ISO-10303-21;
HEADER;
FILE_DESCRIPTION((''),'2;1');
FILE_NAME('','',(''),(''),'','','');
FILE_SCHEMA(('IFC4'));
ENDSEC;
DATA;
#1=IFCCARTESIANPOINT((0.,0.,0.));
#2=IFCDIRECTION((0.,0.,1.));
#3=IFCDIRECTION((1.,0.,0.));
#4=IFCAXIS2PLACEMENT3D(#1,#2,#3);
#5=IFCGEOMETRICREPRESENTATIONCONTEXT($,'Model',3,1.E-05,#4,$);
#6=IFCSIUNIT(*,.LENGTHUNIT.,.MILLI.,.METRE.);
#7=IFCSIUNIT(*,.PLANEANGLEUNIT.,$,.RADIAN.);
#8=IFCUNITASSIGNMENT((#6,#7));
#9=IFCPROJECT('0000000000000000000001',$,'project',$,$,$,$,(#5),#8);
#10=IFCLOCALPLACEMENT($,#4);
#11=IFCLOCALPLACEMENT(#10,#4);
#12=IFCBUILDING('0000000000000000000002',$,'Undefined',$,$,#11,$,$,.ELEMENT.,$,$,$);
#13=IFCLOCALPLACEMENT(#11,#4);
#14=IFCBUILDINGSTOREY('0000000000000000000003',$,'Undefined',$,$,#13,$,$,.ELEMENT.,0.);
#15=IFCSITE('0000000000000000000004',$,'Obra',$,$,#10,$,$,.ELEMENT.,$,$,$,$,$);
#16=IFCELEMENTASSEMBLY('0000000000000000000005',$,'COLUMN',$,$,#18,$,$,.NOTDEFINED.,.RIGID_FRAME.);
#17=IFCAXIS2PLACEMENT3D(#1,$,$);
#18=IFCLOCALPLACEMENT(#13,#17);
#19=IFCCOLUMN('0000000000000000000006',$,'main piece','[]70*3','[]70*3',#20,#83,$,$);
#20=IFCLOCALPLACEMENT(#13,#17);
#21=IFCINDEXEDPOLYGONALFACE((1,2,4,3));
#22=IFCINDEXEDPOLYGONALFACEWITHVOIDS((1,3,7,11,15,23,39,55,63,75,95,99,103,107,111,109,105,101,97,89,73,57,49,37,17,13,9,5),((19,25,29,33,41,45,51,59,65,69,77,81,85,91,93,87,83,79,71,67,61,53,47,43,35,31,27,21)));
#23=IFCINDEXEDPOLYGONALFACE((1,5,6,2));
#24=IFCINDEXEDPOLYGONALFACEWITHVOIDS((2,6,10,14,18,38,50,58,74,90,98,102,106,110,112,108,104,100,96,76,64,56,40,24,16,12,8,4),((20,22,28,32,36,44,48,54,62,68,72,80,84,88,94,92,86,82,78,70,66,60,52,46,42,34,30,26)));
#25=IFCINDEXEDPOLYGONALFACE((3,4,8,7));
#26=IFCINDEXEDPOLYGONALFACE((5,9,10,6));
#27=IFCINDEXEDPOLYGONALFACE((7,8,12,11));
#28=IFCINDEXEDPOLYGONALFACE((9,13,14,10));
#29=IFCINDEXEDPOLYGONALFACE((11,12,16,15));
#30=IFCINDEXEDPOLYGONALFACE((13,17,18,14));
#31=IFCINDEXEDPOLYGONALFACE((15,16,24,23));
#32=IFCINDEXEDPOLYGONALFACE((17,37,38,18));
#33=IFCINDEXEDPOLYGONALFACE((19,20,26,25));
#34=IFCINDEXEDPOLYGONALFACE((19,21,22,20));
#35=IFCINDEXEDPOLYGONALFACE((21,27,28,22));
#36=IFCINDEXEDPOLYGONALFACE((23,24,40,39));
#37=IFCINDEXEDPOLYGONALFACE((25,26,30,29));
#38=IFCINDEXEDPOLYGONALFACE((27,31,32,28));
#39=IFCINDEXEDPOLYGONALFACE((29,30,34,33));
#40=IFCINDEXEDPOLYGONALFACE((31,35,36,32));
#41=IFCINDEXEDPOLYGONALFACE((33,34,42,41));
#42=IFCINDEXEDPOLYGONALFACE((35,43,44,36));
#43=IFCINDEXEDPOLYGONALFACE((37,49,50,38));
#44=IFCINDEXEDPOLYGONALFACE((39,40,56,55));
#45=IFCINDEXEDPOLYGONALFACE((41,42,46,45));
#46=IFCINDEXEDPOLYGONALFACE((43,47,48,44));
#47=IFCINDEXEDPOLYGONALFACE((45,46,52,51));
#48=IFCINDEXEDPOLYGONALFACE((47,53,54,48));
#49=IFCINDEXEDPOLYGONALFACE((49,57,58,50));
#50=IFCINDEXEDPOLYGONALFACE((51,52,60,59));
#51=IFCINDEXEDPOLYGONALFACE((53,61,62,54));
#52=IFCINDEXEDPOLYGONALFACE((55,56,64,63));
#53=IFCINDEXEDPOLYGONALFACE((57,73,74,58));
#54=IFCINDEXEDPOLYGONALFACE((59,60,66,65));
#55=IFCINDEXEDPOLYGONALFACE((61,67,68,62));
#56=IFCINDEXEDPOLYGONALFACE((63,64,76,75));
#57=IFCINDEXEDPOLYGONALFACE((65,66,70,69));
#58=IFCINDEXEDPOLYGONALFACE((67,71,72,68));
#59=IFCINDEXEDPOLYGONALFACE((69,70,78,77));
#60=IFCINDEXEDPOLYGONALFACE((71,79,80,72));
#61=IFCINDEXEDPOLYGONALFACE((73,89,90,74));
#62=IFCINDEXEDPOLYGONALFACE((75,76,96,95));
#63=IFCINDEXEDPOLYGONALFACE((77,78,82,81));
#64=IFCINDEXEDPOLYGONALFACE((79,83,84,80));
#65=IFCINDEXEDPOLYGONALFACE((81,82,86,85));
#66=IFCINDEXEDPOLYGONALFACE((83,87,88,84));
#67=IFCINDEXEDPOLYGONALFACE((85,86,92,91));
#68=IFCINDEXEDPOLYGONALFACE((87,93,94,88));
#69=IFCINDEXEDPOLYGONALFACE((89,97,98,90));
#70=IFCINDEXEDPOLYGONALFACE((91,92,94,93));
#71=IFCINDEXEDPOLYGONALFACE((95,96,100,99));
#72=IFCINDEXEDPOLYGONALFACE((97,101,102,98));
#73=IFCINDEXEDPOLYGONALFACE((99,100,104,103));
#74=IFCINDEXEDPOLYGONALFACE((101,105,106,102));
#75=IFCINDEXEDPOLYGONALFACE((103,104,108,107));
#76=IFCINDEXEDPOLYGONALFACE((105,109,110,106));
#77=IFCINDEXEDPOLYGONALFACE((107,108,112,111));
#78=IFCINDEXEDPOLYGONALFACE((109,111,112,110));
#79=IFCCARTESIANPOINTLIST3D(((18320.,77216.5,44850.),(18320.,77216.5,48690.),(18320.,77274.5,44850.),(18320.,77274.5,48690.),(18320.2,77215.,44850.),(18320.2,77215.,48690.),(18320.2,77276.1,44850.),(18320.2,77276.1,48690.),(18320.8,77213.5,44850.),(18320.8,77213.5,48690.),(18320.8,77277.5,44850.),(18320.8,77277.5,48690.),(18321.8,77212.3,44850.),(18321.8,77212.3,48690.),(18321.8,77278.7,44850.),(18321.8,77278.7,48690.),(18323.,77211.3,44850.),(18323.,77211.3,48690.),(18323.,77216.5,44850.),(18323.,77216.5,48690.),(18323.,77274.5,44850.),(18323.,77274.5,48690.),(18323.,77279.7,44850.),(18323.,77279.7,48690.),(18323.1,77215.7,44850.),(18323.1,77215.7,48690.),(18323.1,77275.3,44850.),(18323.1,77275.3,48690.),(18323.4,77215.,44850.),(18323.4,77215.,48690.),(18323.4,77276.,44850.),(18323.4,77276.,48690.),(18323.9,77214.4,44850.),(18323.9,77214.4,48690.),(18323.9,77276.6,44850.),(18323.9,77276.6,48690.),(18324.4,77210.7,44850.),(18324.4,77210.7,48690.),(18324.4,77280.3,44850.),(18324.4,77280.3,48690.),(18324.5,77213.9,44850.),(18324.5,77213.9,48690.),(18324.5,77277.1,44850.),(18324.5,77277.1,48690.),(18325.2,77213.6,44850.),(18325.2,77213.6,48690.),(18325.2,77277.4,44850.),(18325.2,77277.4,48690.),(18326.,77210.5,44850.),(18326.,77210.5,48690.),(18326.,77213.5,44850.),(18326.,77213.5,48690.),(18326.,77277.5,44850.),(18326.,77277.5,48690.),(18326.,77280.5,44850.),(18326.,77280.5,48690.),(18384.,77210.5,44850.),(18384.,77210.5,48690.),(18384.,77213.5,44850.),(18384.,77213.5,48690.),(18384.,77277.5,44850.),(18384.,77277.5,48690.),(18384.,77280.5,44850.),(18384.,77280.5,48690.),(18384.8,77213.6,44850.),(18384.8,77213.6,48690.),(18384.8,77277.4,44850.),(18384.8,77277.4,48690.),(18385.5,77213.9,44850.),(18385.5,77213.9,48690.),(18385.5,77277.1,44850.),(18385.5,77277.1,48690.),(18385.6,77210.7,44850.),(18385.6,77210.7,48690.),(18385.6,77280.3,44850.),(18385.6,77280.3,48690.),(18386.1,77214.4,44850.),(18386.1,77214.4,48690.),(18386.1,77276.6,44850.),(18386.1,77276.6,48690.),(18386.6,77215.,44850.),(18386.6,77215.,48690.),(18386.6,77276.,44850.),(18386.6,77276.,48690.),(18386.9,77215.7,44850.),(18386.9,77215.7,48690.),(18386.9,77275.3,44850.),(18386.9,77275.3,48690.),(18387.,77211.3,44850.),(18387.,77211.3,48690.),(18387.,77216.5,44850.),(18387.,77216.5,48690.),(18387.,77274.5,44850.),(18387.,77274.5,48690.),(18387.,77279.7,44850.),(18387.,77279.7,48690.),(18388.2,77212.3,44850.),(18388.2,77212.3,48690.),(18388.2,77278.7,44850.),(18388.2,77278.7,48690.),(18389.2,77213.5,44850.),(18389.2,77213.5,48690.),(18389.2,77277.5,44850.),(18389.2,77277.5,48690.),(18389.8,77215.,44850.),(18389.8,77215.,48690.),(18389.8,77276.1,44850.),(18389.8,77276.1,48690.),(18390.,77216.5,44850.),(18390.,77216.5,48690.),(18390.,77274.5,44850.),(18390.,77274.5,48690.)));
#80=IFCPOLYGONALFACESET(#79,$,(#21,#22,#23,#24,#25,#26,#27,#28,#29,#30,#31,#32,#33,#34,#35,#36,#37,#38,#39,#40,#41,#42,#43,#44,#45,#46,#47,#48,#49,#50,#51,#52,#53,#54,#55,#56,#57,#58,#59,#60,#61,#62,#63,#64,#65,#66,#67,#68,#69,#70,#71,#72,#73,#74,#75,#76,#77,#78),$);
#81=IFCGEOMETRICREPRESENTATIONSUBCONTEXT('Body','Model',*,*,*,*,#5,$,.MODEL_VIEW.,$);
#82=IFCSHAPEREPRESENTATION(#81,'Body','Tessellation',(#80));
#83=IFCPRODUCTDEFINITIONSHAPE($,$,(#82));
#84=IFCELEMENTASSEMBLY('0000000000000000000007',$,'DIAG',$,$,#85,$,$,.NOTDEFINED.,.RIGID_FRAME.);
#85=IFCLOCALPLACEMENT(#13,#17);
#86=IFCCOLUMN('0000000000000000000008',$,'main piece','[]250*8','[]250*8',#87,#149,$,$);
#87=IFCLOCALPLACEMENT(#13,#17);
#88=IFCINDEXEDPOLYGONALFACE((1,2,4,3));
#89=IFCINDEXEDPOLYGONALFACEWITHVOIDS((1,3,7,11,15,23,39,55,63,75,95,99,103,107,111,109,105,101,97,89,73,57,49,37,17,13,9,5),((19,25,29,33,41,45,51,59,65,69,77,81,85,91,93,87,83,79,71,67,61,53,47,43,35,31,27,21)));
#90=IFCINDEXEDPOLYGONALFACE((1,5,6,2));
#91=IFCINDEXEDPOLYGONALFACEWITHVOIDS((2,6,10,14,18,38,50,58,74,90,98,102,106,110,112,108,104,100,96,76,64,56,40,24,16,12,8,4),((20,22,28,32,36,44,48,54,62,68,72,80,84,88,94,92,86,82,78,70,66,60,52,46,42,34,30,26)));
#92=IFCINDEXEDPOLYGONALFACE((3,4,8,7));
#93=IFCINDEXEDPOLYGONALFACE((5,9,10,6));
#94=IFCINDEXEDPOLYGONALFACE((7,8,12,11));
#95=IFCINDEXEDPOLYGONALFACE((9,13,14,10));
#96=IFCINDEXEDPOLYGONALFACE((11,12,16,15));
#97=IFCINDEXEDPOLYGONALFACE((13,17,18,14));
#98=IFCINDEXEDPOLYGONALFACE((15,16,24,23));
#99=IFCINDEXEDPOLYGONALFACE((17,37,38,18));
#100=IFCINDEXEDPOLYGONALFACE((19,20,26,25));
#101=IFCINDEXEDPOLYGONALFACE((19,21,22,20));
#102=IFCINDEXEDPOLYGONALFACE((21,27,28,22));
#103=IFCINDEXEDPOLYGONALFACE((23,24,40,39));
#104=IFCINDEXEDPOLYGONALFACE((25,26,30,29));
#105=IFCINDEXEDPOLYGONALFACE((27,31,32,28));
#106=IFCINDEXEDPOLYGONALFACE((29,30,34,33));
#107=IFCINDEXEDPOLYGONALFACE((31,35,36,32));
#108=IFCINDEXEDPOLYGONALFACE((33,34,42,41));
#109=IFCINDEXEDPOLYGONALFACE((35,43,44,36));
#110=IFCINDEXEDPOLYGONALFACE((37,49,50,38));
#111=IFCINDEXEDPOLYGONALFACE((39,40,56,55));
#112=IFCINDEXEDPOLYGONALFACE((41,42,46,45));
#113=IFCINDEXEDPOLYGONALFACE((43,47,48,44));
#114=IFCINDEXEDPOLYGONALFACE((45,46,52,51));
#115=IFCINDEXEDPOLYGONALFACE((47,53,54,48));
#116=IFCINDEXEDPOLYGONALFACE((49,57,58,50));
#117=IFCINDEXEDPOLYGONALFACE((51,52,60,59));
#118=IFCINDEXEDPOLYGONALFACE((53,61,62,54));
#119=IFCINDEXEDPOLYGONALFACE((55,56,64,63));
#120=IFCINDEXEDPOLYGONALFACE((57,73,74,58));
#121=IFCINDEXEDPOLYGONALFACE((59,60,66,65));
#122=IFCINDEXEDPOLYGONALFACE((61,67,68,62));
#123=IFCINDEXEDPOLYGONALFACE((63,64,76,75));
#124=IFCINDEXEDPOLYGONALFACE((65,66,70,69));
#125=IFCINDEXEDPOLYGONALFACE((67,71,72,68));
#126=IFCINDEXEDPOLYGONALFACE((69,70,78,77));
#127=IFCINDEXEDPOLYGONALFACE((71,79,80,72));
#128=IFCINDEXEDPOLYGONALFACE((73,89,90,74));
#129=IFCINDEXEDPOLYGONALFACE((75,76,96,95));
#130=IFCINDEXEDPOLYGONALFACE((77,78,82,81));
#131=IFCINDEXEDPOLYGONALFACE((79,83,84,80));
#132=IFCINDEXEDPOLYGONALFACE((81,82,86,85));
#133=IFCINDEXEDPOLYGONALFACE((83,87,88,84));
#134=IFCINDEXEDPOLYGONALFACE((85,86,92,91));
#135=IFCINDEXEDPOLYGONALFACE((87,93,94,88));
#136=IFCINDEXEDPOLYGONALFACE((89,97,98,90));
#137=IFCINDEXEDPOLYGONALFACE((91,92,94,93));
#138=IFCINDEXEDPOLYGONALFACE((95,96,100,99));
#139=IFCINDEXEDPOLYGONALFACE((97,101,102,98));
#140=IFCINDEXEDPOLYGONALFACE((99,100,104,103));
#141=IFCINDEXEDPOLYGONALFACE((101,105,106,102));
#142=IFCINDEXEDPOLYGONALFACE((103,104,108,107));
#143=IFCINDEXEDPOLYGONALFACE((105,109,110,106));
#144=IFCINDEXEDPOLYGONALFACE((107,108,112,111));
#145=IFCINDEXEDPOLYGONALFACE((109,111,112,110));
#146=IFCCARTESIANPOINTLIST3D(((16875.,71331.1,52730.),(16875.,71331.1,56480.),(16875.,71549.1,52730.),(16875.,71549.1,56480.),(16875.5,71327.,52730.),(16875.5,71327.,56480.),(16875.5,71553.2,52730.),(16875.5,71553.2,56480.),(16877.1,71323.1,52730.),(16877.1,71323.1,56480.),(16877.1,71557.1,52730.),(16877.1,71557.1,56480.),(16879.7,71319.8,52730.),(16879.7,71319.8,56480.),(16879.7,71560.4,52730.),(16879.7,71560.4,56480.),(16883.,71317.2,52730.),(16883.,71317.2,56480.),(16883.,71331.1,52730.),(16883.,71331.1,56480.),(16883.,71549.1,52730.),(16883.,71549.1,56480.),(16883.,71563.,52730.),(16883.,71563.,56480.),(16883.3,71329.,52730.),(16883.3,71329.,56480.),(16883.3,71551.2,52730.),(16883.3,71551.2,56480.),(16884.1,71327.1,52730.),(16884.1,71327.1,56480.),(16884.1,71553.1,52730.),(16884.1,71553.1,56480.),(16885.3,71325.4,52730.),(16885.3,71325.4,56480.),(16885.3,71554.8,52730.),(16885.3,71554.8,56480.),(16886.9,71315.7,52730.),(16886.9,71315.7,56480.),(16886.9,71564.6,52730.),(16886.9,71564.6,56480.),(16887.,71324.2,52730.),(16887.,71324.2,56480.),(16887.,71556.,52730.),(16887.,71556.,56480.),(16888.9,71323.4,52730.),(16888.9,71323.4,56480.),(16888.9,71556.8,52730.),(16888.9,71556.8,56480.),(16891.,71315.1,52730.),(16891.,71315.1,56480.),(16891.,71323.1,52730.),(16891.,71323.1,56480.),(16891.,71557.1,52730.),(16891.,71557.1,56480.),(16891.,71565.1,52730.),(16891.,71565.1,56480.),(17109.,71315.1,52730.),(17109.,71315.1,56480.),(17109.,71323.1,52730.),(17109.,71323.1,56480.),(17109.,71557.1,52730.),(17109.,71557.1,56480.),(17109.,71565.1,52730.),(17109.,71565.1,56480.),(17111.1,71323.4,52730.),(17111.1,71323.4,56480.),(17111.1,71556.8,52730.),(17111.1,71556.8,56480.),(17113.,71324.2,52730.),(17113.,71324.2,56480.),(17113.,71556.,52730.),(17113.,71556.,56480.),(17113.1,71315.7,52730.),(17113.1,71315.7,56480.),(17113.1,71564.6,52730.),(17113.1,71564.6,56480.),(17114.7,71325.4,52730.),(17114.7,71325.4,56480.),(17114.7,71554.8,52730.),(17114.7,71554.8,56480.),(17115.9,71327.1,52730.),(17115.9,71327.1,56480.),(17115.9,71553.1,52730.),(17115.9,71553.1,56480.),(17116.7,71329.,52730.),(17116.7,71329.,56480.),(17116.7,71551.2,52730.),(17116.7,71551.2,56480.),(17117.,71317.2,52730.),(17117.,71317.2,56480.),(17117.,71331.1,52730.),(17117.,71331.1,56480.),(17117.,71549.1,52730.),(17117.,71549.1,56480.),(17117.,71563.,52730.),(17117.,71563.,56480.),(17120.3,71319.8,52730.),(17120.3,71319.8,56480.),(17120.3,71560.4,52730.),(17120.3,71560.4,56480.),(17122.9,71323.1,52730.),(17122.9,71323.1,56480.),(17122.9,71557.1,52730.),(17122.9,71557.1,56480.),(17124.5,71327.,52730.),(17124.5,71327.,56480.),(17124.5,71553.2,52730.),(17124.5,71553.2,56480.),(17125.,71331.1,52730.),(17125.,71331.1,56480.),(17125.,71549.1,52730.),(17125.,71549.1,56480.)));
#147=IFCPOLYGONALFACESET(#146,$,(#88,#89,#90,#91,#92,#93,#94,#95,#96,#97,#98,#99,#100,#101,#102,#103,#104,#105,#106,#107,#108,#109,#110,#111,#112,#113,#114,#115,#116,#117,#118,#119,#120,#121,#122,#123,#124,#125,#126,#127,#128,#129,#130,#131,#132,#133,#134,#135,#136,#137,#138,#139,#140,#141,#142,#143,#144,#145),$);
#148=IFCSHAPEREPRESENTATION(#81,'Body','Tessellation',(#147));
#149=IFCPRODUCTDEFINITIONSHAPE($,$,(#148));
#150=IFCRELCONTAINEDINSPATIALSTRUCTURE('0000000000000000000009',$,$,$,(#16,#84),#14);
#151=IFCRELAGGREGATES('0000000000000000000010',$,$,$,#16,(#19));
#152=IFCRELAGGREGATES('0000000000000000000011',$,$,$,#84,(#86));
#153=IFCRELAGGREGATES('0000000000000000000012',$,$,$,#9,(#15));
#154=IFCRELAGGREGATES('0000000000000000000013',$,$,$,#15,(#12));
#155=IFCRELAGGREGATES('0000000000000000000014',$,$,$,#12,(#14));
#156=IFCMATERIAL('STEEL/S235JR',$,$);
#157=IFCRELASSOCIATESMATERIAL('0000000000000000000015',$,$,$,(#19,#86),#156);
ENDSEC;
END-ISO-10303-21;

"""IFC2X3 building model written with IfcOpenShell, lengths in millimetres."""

from ifc_helpers import new_model, si_unit, frame, origin_with_axes, origin_2d_with_axis, place, context, subcontext, project, spatial, hollow_rectangle, extrude, material, element, aggregate, save


model = new_model("IFC2X3")

# Units and contexts
model_context = context("Model", 3, precision=1e-05, world=origin_with_axes())
body_context = subcontext(model_context, "Body", "Model", "MODEL_VIEW")
ifc_project = project(units=[si_unit("LENGTHUNIT", "METRE", prefix="MILLI"), si_unit("PLANEANGLEUNIT", "RADIAN")], contexts=[model_context])

# Site, building, storey
site_placement = place(None, origin_with_axes())
site = spatial("IfcSite", under=ifc_project, at=site_placement, Name="Obra", CompositionType="ELEMENT")
building_placement = place(site_placement, origin_with_axes())
building = spatial("IfcBuilding", under=site, at=building_placement, Name="Undefined", CompositionType="ELEMENT")
storey_placement = place(building_placement, origin_with_axes())
storey = spatial("IfcBuildingStorey", under=building, at=storey_placement, Name="Undefined", CompositionType="ELEMENT", Elevation=0.0)

# Element assemblies, columns
ifc_material = material(Name="STEEL/S235JR")
assembly_1_placement = place(storey_placement, origin_with_axes())
assembly_1 = element("IfcElementAssembly", 1, at=assembly_1_placement, inside=storey, Name="COLUMN", AssemblyPlace="NOTDEFINED", PredefinedType="RIGID_FRAME")
column_1_placement = place(assembly_1_placement, frame((18355.0, 77245.5, 44850.0), z_axis=(0.0, 0.0, 1.0), x_axis=(0.0, 1.0, 0.0)))
column_1 = element("IfcColumn", 2, at=column_1_placement, material=ifc_material, Name="main piece", Description="[]70*3", ObjectType="[]70*3", context=body_context, shape_type="SweptSolid", body=[
    extrude(hollow_rectangle(XDim=70.0, YDim=70.0, WallThickness=3.0, InnerFilletRadius=3.0, OuterFilletRadius=6.0, at=origin_2d_with_axis()), frame((0.0, 0.0, 3840.0), z_axis=(0.0, 0.0, -1.0), x_axis=(0.0, 1.0, 0.0)), (0.0, 0.0, 1.0), 3840.0),
])
aggregate(assembly_1, [column_1])
assembly_2_placement = place(storey_placement, origin_with_axes())
assembly_2 = element("IfcElementAssembly", 3, at=assembly_2_placement, inside=storey, Name="DIAG", AssemblyPlace="NOTDEFINED", PredefinedType="RIGID_FRAME")
column_2_placement = place(assembly_2_placement, frame((17000.0, 71440.1, 52730.0), z_axis=(0.0, 0.0, 1.0), x_axis=(-1.0, 0.0, 0.0)))
column_2 = element("IfcColumn", 4, at=column_2_placement, material=ifc_material, Name="main piece", Description="[]250*8", ObjectType="[]250*8", context=body_context, shape_type="SweptSolid", body=[
    extrude(hollow_rectangle(XDim=250.0, YDim=250.0, WallThickness=8.0, InnerFilletRadius=8.0, OuterFilletRadius=16.0, at=origin_2d_with_axis()), frame((0.0, 0.0, 3750.0), z_axis=(0.0, 0.0, -1.0), x_axis=(0.0, 1.0, 0.0)), (0.0, 0.0, 1.0), 3750.0),
])
aggregate(assembly_2, [column_2])

save(model, "model.ifc")
